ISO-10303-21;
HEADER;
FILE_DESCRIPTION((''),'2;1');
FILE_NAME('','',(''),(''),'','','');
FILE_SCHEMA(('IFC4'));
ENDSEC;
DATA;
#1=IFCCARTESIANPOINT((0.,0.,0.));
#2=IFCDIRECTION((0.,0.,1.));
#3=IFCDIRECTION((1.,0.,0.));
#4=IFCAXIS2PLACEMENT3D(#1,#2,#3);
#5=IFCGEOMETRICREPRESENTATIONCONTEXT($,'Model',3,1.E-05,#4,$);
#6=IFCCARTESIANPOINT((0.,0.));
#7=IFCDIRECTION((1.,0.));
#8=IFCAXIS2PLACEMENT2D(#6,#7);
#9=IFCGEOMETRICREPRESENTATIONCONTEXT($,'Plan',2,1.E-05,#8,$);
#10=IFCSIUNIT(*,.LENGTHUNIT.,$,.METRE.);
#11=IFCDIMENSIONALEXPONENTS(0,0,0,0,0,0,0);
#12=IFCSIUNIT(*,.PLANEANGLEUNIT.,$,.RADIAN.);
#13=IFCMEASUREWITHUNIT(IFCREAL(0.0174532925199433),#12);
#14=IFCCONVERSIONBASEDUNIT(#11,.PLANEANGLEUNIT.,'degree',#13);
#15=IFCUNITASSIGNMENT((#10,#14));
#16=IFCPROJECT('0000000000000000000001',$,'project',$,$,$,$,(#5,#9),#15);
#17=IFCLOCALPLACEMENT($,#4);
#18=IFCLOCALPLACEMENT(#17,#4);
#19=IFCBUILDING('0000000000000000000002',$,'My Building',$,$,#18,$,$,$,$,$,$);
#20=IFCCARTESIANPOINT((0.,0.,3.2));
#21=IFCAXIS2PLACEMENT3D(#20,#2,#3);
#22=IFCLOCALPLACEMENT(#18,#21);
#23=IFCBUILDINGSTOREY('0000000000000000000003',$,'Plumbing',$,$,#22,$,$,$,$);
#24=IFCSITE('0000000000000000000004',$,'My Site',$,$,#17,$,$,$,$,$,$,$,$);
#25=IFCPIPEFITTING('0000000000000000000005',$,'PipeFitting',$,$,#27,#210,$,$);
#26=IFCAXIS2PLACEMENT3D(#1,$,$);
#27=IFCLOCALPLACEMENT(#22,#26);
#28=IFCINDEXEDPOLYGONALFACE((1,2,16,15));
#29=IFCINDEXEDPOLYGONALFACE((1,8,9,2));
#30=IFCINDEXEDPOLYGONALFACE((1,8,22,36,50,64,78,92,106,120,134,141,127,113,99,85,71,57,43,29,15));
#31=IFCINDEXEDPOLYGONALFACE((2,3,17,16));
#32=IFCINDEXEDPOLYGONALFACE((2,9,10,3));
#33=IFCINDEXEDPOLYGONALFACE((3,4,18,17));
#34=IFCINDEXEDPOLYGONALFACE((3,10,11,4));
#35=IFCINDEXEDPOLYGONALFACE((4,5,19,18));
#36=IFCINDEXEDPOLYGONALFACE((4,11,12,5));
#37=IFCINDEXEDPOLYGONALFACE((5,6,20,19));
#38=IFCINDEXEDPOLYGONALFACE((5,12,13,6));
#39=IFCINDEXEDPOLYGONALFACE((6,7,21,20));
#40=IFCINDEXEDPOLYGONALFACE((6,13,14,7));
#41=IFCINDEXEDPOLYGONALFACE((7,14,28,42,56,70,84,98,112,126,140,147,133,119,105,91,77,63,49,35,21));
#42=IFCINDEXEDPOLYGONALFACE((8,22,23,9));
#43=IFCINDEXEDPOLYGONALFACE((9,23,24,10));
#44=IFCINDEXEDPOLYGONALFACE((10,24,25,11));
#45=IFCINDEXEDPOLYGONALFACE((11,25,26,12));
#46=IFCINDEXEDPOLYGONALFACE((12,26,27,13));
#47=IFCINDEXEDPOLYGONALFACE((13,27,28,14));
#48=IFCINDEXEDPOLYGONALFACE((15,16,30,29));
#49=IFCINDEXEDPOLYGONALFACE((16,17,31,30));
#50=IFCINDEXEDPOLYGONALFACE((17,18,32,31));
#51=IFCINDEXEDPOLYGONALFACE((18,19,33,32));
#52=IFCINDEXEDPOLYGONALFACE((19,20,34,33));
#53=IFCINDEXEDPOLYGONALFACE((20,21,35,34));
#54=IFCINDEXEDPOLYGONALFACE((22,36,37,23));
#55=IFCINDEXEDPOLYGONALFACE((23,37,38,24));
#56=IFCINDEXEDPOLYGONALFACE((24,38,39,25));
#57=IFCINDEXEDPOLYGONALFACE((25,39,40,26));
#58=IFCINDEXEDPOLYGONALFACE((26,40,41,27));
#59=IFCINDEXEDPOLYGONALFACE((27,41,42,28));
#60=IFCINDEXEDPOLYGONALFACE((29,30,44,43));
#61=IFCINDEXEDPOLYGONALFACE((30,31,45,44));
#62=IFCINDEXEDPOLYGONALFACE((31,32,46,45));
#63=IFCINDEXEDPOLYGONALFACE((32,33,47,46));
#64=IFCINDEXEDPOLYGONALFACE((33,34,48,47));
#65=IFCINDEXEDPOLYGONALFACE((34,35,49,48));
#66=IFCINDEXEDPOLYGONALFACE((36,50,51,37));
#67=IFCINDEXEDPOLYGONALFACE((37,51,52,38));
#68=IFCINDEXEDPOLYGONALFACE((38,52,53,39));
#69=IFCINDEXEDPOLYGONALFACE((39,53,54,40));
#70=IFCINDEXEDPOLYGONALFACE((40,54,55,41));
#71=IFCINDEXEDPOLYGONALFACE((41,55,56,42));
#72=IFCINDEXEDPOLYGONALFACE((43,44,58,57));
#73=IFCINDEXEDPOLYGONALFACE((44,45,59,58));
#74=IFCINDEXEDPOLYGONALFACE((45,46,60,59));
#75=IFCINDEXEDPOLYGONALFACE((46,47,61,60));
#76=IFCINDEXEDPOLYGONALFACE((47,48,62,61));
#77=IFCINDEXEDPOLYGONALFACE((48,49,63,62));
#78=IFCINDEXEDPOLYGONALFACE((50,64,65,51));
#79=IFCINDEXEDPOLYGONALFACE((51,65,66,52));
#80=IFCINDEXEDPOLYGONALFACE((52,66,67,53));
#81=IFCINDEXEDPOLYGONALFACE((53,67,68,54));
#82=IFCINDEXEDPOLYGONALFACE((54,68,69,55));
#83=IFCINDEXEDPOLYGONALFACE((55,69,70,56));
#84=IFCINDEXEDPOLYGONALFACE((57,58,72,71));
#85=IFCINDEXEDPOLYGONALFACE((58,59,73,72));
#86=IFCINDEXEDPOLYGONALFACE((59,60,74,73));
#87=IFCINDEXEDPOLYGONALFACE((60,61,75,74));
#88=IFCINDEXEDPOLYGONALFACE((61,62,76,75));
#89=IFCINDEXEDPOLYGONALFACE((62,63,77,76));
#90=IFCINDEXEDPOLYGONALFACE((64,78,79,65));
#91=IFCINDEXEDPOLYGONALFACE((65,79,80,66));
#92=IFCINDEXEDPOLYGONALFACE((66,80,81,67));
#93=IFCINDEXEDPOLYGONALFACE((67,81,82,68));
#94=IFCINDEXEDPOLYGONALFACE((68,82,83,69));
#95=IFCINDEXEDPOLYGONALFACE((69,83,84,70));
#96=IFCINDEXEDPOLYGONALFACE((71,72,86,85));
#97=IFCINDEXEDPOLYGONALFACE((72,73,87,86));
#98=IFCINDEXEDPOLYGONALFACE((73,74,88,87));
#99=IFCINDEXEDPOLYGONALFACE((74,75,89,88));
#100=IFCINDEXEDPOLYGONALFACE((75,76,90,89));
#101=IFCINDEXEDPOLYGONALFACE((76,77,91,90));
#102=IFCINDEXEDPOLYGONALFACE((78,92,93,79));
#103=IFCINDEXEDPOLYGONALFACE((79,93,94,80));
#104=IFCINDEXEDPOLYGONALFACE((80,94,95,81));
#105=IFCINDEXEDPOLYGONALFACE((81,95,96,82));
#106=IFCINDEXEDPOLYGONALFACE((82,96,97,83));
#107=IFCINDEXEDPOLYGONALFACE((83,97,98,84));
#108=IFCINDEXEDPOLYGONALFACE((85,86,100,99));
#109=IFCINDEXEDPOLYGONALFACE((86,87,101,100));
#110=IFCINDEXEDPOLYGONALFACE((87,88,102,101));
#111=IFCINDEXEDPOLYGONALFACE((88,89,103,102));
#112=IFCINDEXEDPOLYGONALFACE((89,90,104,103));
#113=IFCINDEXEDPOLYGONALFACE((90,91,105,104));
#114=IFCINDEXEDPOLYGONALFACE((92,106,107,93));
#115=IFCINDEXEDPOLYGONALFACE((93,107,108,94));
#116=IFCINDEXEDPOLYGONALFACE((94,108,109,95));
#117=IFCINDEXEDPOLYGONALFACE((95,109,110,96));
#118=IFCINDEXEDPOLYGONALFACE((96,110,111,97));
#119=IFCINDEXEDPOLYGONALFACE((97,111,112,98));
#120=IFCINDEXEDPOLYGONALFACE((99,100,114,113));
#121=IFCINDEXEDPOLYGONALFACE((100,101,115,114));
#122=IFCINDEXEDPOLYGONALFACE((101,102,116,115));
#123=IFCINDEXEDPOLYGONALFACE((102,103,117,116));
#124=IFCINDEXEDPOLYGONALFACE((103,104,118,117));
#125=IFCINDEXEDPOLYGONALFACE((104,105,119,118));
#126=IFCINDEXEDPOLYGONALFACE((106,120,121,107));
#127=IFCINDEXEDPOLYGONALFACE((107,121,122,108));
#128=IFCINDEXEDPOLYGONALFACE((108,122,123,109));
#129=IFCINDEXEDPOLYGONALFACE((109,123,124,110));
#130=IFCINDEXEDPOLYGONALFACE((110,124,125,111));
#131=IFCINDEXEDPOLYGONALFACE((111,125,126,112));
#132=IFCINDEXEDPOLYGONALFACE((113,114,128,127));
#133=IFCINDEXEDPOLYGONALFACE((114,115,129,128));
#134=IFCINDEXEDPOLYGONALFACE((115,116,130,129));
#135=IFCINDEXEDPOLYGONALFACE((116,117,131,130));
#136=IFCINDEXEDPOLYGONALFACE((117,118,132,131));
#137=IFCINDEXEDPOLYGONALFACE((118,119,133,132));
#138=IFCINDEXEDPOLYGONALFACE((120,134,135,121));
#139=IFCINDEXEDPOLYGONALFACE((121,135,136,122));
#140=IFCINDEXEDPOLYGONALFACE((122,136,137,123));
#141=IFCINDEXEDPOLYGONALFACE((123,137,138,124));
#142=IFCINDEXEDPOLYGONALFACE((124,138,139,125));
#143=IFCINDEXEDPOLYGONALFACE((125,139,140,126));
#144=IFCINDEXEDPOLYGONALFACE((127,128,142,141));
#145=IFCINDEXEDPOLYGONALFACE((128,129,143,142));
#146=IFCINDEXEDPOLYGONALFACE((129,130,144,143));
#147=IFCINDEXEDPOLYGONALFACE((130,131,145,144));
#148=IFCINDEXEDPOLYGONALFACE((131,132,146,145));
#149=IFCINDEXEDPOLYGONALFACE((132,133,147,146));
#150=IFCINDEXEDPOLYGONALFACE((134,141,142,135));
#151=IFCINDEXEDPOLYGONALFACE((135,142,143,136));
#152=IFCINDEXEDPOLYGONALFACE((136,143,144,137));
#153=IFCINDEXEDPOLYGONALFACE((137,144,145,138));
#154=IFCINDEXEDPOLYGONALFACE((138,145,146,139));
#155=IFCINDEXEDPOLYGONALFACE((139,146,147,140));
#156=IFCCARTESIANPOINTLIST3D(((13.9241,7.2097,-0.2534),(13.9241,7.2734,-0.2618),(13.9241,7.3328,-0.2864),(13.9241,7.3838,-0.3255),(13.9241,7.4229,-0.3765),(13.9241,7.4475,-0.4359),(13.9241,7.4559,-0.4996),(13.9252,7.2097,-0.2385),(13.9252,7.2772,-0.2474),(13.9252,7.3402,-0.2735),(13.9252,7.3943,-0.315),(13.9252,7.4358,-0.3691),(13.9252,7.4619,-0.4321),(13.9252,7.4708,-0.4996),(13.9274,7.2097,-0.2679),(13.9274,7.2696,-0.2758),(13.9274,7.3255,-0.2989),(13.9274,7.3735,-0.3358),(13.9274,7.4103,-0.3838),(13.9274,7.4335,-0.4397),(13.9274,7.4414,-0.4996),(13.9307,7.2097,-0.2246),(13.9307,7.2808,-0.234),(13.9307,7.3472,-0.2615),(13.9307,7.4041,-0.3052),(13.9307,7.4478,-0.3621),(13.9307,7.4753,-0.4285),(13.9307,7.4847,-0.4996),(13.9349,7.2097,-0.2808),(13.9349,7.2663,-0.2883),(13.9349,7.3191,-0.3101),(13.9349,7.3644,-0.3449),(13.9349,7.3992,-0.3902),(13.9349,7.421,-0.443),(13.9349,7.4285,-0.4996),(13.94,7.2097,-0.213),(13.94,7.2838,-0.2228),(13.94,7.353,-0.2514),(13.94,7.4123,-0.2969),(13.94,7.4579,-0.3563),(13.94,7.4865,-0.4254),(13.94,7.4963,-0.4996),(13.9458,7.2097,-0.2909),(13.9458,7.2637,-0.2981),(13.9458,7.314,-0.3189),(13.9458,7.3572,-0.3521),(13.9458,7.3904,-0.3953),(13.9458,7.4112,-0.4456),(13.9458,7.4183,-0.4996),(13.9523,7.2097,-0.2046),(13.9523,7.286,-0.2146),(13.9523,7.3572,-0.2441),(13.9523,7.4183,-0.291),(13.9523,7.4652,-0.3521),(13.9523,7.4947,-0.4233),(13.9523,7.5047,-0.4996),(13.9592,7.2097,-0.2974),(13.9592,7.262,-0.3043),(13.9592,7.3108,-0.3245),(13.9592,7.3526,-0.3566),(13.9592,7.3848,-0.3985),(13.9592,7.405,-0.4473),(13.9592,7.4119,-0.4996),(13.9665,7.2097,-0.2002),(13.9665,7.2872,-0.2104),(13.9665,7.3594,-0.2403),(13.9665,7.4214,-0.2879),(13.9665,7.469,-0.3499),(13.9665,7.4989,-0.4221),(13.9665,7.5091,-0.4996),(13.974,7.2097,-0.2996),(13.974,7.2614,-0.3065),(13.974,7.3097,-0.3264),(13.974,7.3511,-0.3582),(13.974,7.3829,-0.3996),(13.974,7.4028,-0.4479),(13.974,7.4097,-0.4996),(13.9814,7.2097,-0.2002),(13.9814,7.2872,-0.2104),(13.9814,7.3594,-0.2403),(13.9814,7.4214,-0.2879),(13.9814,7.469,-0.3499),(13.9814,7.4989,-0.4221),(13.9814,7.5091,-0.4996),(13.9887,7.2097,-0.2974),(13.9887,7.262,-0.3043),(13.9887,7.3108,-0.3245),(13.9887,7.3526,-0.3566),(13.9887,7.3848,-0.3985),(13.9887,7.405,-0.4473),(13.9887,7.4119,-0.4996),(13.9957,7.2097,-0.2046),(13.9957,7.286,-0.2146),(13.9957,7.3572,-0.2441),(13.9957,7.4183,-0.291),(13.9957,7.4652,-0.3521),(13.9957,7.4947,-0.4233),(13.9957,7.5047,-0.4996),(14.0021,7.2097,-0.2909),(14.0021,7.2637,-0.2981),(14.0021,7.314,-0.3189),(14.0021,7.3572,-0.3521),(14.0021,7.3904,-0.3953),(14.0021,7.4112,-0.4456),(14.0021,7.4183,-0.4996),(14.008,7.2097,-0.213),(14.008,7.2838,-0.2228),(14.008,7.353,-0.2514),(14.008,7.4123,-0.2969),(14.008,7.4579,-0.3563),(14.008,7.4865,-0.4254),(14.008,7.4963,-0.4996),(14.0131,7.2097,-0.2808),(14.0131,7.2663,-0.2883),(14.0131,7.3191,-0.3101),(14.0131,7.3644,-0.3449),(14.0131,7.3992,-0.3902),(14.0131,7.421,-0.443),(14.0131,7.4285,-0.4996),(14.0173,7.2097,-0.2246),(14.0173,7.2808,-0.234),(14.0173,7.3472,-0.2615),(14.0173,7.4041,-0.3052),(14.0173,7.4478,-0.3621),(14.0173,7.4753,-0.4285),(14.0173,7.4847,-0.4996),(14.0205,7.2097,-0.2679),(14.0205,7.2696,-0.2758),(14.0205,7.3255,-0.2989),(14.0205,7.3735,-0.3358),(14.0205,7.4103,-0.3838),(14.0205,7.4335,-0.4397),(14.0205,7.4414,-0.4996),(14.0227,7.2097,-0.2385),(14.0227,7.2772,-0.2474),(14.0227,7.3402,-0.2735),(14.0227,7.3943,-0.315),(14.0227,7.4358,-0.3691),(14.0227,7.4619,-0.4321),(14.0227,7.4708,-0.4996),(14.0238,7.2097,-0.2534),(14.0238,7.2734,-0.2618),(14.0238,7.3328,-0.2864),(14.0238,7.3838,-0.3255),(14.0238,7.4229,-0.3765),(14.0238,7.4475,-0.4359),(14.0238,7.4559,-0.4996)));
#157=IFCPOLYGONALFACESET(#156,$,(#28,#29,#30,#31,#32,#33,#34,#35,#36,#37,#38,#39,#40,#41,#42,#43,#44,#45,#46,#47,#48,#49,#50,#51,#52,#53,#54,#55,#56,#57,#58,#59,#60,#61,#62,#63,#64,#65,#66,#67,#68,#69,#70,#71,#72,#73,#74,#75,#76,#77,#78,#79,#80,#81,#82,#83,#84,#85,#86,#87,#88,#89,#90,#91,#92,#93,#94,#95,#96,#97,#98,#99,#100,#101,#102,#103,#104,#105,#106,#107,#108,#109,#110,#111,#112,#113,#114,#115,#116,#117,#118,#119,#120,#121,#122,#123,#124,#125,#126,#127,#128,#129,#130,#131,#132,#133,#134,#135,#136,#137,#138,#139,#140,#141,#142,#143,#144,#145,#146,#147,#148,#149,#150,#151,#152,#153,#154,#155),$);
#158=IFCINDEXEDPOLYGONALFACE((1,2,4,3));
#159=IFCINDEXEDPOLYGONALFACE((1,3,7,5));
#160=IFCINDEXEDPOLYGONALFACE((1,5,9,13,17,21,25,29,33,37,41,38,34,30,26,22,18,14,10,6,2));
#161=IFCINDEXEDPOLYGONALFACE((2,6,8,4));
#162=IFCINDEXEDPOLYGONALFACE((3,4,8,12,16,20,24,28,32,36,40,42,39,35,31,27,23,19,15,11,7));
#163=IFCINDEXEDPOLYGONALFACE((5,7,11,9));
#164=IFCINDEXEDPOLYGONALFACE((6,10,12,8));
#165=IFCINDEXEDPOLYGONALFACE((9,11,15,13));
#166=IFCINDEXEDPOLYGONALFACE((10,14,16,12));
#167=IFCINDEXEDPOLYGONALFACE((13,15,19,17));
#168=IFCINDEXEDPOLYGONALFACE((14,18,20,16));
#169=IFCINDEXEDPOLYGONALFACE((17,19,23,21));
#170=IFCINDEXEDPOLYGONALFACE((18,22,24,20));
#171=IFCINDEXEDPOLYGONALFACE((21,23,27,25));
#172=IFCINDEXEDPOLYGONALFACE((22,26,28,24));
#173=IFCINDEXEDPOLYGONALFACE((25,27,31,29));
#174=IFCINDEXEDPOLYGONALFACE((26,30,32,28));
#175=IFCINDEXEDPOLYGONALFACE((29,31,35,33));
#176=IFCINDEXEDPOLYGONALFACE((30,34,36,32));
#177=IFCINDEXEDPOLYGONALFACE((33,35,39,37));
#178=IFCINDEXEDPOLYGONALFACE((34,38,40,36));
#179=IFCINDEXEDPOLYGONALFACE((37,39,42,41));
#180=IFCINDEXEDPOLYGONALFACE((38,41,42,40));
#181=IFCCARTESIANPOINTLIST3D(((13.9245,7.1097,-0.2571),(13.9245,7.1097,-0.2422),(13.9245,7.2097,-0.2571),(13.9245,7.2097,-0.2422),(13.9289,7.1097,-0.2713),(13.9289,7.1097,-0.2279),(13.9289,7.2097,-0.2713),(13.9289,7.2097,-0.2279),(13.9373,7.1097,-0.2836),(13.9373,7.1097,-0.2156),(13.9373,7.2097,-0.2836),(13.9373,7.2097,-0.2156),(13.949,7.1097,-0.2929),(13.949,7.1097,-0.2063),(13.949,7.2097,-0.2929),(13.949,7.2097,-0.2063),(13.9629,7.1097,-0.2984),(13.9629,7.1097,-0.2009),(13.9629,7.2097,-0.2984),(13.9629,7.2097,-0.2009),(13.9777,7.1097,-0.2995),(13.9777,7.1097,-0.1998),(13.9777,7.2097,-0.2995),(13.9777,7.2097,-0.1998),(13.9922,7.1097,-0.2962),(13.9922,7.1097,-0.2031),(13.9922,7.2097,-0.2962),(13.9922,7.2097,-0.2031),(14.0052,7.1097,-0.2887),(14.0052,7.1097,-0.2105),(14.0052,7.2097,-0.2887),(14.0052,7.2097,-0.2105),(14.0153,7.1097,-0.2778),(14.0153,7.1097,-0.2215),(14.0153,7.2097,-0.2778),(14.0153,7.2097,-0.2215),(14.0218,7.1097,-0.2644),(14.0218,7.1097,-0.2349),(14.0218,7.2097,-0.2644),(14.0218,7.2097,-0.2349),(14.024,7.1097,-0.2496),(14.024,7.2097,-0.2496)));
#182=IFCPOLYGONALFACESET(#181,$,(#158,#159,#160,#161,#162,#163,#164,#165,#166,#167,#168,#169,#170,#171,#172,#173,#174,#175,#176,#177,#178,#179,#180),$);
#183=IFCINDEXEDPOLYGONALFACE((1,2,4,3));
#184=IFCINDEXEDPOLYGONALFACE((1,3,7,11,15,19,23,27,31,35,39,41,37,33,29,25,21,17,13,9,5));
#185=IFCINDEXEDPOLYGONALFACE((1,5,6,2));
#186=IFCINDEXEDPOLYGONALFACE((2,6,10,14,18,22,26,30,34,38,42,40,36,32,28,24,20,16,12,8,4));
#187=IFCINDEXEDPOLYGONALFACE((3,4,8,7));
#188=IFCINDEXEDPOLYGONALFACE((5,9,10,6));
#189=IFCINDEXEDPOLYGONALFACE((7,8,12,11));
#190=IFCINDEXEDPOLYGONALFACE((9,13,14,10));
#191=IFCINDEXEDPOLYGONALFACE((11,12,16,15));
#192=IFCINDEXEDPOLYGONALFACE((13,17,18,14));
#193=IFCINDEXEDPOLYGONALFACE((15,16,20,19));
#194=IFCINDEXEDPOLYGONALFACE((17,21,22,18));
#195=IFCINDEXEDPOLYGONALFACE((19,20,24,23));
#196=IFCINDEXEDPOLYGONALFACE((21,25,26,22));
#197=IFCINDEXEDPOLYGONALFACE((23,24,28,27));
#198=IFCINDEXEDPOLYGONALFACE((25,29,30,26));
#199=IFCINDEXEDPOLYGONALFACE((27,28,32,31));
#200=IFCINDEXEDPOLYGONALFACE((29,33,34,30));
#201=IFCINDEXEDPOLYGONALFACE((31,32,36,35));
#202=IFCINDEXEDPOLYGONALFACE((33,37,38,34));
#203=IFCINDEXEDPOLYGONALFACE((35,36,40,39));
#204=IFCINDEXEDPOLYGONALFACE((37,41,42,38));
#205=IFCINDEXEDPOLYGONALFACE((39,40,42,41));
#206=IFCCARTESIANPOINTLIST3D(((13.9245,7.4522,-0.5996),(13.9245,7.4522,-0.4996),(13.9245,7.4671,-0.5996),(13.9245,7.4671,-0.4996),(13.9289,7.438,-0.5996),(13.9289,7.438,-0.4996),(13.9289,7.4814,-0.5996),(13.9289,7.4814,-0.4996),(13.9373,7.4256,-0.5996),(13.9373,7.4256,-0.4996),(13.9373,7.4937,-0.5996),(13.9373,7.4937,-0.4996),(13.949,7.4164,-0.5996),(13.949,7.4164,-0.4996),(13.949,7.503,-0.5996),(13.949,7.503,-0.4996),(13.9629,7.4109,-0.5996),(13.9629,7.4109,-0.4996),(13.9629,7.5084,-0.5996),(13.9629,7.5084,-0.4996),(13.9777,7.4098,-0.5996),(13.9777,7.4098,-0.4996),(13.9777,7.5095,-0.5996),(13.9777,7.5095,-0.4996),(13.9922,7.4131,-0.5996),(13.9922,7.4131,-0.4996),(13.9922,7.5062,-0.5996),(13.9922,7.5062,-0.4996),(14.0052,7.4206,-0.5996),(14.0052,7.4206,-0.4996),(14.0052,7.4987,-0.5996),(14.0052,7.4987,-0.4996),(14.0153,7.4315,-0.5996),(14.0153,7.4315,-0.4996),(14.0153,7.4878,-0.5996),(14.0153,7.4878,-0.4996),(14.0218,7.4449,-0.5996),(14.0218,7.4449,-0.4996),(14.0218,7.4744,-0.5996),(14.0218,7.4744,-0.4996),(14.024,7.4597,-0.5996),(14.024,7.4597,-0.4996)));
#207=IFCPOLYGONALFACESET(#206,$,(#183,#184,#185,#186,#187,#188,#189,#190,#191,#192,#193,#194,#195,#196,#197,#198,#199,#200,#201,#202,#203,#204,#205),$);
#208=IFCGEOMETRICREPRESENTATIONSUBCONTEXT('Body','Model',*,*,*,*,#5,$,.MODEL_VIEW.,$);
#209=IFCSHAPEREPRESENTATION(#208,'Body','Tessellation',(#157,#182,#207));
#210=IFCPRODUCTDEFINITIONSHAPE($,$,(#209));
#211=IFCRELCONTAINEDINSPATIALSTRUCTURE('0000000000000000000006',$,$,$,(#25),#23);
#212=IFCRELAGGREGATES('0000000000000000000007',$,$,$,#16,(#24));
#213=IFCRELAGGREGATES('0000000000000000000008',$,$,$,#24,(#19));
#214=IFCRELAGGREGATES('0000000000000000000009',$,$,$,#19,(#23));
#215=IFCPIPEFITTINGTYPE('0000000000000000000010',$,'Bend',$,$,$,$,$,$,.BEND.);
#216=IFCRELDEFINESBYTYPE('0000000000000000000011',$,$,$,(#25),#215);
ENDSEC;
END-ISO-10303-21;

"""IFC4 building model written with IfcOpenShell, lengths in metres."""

from ifc_helpers import new_model, entity, si_unit, converted_unit, frame, origin_with_axes, origin_2d_with_axis, place, context, subcontext, project, spatial, circle, extrude, source, transform, mapped, type_object, type_shapes, element, save


model = new_model("IFC4")

# Units and contexts
model_context = context("Model", 3, precision=1e-05, world=origin_with_axes())
plan_context = context("Plan", 2, precision=1e-05, world=origin_2d_with_axis())
body_context = subcontext(model_context, "Body", "Model", "MODEL_VIEW")
ifc_project = project(units=[si_unit("LENGTHUNIT", "METRE"), converted_unit("PLANEANGLEUNIT", "degree", entity("IfcReal", 0.0174532925199433), si_unit("PLANEANGLEUNIT", "RADIAN"), dimensions=[0, 0, 0, 0, 0, 0, 0])], contexts=[model_context, plan_context])

# Site, building, storey
site_placement = place(None, origin_with_axes())
site = spatial("IfcSite", under=ifc_project, at=site_placement, Name="My Site")
building_placement = place(site_placement, origin_with_axes())
building = spatial("IfcBuilding", under=site, at=building_placement, Name="My Building")
storey_placement = place(building_placement, frame((0.0, 0.0, 3.2), z_axis=(0.0, 0.0, 1.0), x_axis=(1.0, 0.0, 0.0)))
storey = spatial("IfcBuildingStorey", under=building, at=storey_placement, Name="Plumbing")

# Pipe fitting
pipe_fitting_type = type_object("IfcPipeFittingType", Name="Bend", PredefinedType="BEND")
shared_shape = source(origin_with_axes(), body_context, "Body", "SolidModel", [
    entity("IfcSweptDiskSolid", entity("IfcIndexedPolyCurve", entity("IfcCartesianPointList3D", [[0.0, 0.0, -0.1], [0.0, -0.0732, -0.2768], [0.0, -0.25, -0.35]]), [entity("IfcArcIndex", [1, 2, 3])]), 0.05),
    extrude(circle(Radius=0.05), origin_with_axes(), (0.0, 0.0, -1.0), 0.1),
    extrude(circle(Radius=0.05), frame((0.0, -0.25, -0.35), z_axis=(0.0, -1.0, 0.0), x_axis=(1.0, 0.0, 0.0)), (0.0, 0.0, 1.0), 0.1),
])
type_shapes(pipe_fitting_type, [shared_shape])
for number, where, z_axis, x_axis, name in (
    (1, (13.974, 7.1097, -0.2496), (0.0, -1.0, 0.0), (1.0, 0.0, 0.0), "PipeFitting"),
):
    element("IfcPipeFitting", number, at=place(storey_placement, frame(where, z_axis=z_axis, x_axis=x_axis)), inside=storey, type_object=pipe_fitting_type, Name=name, context=body_context, shape_type="MappedRepresentation", body=[
        mapped(shared_shape, transform((0.0, 0.0, 0.0), x_axis=(1.0, 0.0, 0.0), y_axis=(0.0, 1.0, 0.0), z_axis=(0.0, 0.0, 1.0), scale=1.0)),
    ])

save(model, "model.ifc")
